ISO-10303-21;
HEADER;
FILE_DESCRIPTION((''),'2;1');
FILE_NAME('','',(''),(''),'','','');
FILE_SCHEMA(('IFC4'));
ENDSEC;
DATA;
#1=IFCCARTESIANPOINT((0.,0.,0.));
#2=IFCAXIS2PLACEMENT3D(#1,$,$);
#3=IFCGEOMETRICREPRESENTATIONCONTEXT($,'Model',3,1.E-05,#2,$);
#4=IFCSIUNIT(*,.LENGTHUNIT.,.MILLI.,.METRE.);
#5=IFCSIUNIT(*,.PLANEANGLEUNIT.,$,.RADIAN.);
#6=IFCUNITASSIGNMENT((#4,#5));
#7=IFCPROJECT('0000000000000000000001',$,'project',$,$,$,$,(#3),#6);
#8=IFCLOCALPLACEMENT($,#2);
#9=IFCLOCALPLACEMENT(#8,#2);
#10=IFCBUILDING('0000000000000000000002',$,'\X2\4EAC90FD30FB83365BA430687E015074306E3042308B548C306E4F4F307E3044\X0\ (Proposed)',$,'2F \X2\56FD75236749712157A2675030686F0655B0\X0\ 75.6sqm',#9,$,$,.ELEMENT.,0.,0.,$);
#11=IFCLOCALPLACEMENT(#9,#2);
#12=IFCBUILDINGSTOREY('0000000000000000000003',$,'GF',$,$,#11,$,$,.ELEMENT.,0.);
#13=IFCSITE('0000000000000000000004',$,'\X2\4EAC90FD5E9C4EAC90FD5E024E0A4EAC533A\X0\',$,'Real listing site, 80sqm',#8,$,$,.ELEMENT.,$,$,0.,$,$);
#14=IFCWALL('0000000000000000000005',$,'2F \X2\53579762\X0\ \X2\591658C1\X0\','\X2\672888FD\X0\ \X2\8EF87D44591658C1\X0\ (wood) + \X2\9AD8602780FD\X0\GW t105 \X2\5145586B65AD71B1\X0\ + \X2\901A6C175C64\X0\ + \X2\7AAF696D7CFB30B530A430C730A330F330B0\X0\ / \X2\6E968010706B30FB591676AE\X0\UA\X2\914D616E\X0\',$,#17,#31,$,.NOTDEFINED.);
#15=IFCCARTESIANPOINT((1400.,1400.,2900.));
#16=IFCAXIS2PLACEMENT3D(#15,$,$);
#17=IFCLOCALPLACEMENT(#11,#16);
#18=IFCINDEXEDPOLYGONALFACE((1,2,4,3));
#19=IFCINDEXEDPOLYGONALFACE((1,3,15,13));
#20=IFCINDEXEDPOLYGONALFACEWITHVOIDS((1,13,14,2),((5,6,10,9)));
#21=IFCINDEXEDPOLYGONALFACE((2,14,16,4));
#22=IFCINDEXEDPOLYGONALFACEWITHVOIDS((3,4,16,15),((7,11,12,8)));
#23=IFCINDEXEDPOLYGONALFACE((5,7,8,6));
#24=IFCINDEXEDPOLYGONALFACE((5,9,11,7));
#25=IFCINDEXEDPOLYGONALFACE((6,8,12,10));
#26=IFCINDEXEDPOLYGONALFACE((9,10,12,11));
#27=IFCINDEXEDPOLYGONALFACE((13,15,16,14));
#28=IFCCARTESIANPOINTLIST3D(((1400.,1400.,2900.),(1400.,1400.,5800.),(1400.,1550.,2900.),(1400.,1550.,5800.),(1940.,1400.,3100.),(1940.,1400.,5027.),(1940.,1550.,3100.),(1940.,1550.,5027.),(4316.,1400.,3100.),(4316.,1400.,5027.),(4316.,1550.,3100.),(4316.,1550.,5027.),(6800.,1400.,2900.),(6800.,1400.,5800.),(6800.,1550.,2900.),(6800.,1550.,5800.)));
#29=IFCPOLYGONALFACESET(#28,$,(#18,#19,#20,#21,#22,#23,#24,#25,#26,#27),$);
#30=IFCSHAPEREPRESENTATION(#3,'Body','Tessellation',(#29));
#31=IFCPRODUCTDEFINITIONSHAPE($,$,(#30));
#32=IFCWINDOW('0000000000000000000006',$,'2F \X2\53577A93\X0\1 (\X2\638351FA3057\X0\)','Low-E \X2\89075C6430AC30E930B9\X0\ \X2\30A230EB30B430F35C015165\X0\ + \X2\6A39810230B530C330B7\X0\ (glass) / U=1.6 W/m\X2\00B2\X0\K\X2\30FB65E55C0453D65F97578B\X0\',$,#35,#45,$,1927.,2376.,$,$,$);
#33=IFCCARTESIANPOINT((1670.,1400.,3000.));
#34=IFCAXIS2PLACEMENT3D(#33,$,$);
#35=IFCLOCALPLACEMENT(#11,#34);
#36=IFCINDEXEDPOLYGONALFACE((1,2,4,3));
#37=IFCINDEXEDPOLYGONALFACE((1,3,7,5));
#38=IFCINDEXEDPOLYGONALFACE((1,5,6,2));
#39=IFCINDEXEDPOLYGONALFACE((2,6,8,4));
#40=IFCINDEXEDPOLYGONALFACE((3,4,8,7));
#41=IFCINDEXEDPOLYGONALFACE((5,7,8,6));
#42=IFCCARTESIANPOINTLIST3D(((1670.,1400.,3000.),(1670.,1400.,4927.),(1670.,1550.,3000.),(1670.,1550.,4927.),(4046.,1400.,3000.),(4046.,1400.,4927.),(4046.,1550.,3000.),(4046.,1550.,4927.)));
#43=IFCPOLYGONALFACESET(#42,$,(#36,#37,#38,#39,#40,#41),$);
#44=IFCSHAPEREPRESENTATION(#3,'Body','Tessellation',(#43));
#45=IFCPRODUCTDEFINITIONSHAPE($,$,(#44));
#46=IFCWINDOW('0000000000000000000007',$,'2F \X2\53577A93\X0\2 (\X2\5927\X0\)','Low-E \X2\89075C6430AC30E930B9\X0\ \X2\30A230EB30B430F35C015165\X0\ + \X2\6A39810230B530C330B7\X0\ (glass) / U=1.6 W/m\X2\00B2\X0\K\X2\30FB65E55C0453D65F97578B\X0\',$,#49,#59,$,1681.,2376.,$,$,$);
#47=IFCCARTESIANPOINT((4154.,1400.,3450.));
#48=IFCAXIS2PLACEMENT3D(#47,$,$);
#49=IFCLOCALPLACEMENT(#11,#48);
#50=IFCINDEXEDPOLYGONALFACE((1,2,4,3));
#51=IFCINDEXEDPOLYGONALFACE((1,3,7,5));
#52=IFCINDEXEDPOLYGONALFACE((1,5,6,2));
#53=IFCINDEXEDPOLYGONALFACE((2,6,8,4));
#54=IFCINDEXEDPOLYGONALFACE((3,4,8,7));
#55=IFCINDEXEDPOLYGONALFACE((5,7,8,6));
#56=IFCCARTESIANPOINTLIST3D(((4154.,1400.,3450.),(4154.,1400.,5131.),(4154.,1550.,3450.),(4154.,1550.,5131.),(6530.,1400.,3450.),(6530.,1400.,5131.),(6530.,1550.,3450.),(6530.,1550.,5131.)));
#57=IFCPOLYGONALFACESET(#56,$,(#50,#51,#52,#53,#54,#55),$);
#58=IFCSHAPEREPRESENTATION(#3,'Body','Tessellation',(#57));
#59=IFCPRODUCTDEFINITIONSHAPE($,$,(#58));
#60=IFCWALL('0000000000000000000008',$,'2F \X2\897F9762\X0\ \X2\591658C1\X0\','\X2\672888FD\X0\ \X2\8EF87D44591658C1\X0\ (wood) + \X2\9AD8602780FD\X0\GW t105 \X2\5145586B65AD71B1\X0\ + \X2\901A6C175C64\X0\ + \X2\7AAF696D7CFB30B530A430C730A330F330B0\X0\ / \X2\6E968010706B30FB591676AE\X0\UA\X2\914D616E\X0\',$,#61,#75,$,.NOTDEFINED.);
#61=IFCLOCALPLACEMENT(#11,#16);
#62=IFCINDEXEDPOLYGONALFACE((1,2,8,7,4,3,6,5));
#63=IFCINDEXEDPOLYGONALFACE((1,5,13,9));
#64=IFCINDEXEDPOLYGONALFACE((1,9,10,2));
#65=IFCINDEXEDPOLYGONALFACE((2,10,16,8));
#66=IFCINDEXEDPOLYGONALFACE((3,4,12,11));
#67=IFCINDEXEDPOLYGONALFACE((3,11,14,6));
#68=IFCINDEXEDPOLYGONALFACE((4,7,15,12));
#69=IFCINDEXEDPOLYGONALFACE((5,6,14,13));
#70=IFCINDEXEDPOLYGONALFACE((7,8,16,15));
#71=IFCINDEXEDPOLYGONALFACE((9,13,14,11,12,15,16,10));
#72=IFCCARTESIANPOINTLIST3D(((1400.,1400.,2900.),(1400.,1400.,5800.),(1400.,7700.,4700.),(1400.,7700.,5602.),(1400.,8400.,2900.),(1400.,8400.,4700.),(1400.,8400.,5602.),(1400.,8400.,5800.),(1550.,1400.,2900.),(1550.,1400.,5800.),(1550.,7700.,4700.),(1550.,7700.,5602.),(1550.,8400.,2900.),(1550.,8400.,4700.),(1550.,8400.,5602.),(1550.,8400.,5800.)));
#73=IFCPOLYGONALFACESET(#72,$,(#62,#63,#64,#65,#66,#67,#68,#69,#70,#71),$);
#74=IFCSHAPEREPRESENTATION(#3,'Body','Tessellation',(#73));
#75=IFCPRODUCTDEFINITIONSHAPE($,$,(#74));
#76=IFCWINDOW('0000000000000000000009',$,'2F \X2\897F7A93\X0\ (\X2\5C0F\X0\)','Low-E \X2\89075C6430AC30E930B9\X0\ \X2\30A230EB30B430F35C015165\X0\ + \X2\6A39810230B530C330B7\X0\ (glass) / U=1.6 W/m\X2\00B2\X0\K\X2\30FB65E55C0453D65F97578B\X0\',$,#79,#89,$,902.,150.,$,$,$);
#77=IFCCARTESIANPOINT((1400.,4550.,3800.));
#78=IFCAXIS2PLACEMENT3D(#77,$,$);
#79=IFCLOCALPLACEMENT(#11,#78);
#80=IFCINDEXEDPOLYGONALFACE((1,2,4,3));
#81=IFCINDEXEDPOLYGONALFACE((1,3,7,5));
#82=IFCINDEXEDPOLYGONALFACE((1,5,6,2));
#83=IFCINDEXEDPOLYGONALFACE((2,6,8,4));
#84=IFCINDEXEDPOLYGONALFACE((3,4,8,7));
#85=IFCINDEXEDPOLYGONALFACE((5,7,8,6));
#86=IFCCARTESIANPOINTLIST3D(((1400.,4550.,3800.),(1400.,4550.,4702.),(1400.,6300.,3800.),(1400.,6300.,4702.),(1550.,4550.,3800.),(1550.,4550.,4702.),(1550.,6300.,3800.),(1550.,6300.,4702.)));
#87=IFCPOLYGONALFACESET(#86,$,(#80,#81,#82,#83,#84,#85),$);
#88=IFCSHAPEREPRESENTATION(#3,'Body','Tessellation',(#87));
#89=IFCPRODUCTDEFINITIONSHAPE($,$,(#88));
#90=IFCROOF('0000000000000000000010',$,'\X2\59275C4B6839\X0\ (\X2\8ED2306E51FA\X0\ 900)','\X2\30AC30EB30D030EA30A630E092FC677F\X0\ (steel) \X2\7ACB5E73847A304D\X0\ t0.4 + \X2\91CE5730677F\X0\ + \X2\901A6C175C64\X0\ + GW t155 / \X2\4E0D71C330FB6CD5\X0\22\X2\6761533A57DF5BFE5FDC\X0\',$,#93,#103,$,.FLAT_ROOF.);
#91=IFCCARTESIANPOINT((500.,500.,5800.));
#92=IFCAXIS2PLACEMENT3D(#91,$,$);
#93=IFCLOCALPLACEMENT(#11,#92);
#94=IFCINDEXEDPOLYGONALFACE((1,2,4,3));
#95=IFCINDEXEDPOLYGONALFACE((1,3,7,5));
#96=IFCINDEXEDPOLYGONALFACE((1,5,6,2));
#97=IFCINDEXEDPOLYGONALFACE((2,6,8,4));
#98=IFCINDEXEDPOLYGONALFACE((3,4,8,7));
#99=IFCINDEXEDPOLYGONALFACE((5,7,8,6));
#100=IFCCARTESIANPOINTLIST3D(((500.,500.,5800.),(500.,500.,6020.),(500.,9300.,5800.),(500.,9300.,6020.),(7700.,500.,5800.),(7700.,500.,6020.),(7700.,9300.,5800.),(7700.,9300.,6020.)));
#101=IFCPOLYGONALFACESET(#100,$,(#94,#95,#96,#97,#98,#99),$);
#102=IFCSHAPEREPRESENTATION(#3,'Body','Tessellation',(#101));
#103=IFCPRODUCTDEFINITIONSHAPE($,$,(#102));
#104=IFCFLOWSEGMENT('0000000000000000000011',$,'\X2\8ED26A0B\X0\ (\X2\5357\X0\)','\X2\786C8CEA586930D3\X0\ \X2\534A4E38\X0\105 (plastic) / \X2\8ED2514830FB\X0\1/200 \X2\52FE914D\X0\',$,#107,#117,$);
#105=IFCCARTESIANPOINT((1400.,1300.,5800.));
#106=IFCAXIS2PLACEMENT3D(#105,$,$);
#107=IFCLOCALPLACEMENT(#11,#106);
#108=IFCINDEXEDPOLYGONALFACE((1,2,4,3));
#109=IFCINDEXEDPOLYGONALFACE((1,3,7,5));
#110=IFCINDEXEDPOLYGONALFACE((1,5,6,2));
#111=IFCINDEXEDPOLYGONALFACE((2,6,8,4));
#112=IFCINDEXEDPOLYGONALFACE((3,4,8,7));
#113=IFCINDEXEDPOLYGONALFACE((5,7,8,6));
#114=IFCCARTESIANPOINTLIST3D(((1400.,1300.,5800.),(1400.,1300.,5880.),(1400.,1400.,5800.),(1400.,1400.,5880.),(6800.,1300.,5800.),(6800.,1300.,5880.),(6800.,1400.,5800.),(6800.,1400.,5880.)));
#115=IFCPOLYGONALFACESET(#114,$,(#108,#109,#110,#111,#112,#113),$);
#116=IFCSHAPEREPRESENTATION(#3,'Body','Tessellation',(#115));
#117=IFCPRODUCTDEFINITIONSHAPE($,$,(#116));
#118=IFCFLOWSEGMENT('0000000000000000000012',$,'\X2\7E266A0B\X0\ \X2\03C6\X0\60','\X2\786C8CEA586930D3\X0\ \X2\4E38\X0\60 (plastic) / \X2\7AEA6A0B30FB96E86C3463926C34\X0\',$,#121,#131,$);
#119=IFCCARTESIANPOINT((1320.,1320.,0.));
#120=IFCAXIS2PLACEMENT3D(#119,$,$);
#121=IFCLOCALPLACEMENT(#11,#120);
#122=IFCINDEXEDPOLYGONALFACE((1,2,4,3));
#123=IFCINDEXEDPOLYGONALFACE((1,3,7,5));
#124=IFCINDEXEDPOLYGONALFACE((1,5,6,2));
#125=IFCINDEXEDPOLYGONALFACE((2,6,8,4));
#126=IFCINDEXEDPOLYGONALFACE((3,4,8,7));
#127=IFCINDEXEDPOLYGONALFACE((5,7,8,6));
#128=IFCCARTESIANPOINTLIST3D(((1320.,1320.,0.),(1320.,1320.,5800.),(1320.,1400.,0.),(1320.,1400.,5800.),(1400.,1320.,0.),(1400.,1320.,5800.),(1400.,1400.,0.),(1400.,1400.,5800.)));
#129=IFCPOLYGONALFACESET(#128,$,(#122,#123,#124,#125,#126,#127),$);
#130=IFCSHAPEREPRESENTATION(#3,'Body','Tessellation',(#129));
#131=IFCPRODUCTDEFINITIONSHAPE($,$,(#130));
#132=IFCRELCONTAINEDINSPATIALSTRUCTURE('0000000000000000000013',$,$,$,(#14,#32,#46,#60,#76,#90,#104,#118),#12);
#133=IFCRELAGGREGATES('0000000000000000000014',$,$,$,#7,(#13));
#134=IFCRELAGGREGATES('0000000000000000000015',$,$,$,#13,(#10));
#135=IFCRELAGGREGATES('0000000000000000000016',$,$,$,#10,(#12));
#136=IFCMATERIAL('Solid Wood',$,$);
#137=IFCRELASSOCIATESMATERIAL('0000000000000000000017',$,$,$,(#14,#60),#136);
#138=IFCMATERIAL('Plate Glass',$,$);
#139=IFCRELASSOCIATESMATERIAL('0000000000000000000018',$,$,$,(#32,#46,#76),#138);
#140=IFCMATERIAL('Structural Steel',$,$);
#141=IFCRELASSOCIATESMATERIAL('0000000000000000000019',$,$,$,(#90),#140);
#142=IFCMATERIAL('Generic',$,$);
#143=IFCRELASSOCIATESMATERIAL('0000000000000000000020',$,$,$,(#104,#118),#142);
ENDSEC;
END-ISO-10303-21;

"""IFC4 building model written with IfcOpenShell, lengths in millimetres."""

from ifc_helpers import new_model, si_unit, frame, frame_2d, origin, place, context, project, spatial, rectangle, extrude, material, element, fill, save


model = new_model("IFC4")

# Units and contexts
model_context = context("Model", 3, precision=1e-05, world=origin())
ifc_project = project(units=[si_unit("LENGTHUNIT", "METRE", prefix="MILLI"), si_unit("PLANEANGLEUNIT", "RADIAN")], contexts=[model_context])

# Site, building, storey
site_placement = place(None, origin())
site = spatial("IfcSite", under=ifc_project, at=site_placement, Name="京都府京都市上京区", ObjectType="Real listing site, 80sqm", CompositionType="ELEMENT", RefElevation=0.0)
building_placement = place(site_placement, origin())
building = spatial("IfcBuilding", under=site, at=building_placement, Name="京都・茶室と縁側のある和の住まい (Proposed)", ObjectType="2F 国産杉無垢材と漆喰 75.6sqm", CompositionType="ELEMENT", ElevationOfRefHeight=0.0, ElevationOfTerrain=0.0)
storey_placement = place(building_placement, origin())
storey = spatial("IfcBuildingStorey", under=building, at=storey_placement, Name="GF", CompositionType="ELEMENT", Elevation=0.0)

# Shared definitions
ifc_material_1 = material(Name="Solid Wood")

# Shared definitions
ifc_material_2 = material(Name="Plate Glass")

# Wall, openings, windows
wall_1_placement = place(storey_placement, frame((1400.0, 1400.0, 2900.0)))
wall_1 = element("IfcWall", 1, at=wall_1_placement, inside=storey, material=ifc_material_1, Name="2F 南面 外壁", Description="木製 軸組外壁 (wood) + 高性能GW t105 充填断熱 + 通気層 + 窯業系サイディング / 準耐火・外皮UA配慮", PredefinedType="NOTDEFINED", context=model_context, shape_type="SweptSolid", body=[
    extrude(rectangle(XDim=5400.0, YDim=150.0, at=frame_2d((2700.0, 75.0))), frame((1400.0, 1400.0, 2900.0)), (0.0, 0.0, 1.0), 2900.0),
])
opening_1_placement = place(storey_placement, frame((1670.0, 1400.0, 3000.0)))
opening_1 = element("IfcOpeningElement", 2, at=opening_1_placement, cuts=wall_1, PredefinedType="NOTDEFINED", context=model_context, shape_type="SweptSolid", body=[
    extrude(rectangle(XDim=2376.0, YDim=150.0, at=frame_2d((1188.0, 75.0))), frame((1670.0, 1400.0, 3000.0)), (0.0, 0.0, 1.0), 1927.0),
])
opening_2_placement = place(storey_placement, frame((4154.0, 1400.0, 3450.0)))
opening_2 = element("IfcOpeningElement", 3, at=opening_2_placement, cuts=wall_1, PredefinedType="NOTDEFINED", context=model_context, shape_type="SweptSolid", body=[
    extrude(rectangle(XDim=2376.0, YDim=150.0, at=frame_2d((1188.0, 75.0))), frame((4154.0, 1400.0, 3450.0)), (0.0, 0.0, 1.0), 1681.0),
])
window_1_placement = place(storey_placement, frame((1670.0, 1400.0, 3000.0)))
window_1 = element("IfcWindow", 4, at=window_1_placement, inside=storey, material=ifc_material_2, Name="2F 南窓1 (掃出し)", Description="Low-E 複層ガラス アルゴン封入 + 樹脂サッシ (glass) / U=1.6 W/m²K・日射取得型", OverallHeight=1927.0, OverallWidth=2376.0, context=model_context, shape_type="SweptSolid", body=[
    extrude(rectangle(XDim=2376.0, YDim=150.0, at=frame_2d((1188.0, 75.0))), frame((1670.0, 1400.0, 3000.0)), (0.0, 0.0, 1.0), 1927.0),
])
fill(opening_1, window_1)
window_2_placement = place(storey_placement, frame((4154.0, 1400.0, 3450.0)))
window_2 = element("IfcWindow", 5, at=window_2_placement, inside=storey, material=ifc_material_2, Name="2F 南窓2 (大)", Description="Low-E 複層ガラス アルゴン封入 + 樹脂サッシ (glass) / U=1.6 W/m²K・日射取得型", OverallHeight=1681.0, OverallWidth=2376.0, context=model_context, shape_type="SweptSolid", body=[
    extrude(rectangle(XDim=2376.0, YDim=150.0, at=frame_2d((1188.0, 75.0))), frame((4154.0, 1400.0, 3450.0)), (0.0, 0.0, 1.0), 1681.0),
])
fill(opening_2, window_2)

# Wall, opening, window
wall_2_placement = place(storey_placement, frame((1400.0, 1400.0, 2900.0)))
wall_2 = element("IfcWall", 6, at=wall_2_placement, inside=storey, material=ifc_material_1, Name="2F 西面 外壁", Description="木製 軸組外壁 (wood) + 高性能GW t105 充填断熱 + 通気層 + 窯業系サイディング / 準耐火・外皮UA配慮", PredefinedType="NOTDEFINED", context=model_context, shape_type="SweptSolid", body=[
    extrude(rectangle(XDim=150.0, YDim=7000.0, at=frame_2d((75.0, 3500.0))), frame((1400.0, 1400.0, 2900.0)), (0.0, 0.0, 1.0), 2900.0),
])
opening_3_placement = place(storey_placement, frame((1400.0, 4550.0, 3800.0)))
opening_3 = element("IfcOpeningElement", 7, at=opening_3_placement, cuts=wall_2, PredefinedType="NOTDEFINED", context=model_context, shape_type="SweptSolid", body=[
    extrude(rectangle(XDim=150.0, YDim=1750.0, at=frame_2d((75.0, 875.0))), frame((1400.0, 4550.0, 3800.0)), (0.0, 0.0, 1.0), 902.0),
])
window_3_placement = place(storey_placement, frame((1400.0, 4550.0, 3800.0)))
window_3 = element("IfcWindow", 8, at=window_3_placement, inside=storey, material=ifc_material_2, Name="2F 西窓 (小)", Description="Low-E 複層ガラス アルゴン封入 + 樹脂サッシ (glass) / U=1.6 W/m²K・日射取得型", OverallHeight=902.0, OverallWidth=150.0, context=model_context, shape_type="SweptSolid", body=[
    extrude(rectangle(XDim=150.0, YDim=1750.0, at=frame_2d((75.0, 875.0))), frame((1400.0, 4550.0, 3800.0)), (0.0, 0.0, 1.0), 902.0),
])
fill(opening_3, window_3)

# Roof
ifc_material_3 = material(Name="Structural Steel")
roof_placement = place(storey_placement, frame((500.0, 500.0, 5800.0)))
element("IfcRoof", 9, at=roof_placement, inside=storey, material=ifc_material_3, Name="大屋根 (軒の出 900)", Description="ガルバリウム鋼板 (steel) 立平葺き t0.4 + 野地板 + 通気層 + GW t155 / 不燃・法22条区域対応", PredefinedType="FLAT_ROOF", context=model_context, shape_type="SweptSolid", body=[
    extrude(rectangle(XDim=7200.0, YDim=8800.0, at=frame_2d((3600.0, 4400.0))), frame((500.0, 500.0, 5800.0)), (0.0, 0.0, 1.0), 220.0),
])

# Flow segments
ifc_material_4 = material(Name="Generic")
flow_segment_1_placement = place(storey_placement, frame((1400.0, 1300.0, 5800.0)))
element("IfcFlowSegment", 10, at=flow_segment_1_placement, inside=storey, material=ifc_material_4, Name="軒樋 (南)", Description="硬質塩ビ 半丸105 (plastic) / 軒先・1/200 勾配", context=model_context, shape_type="SweptSolid", body=[
    extrude(rectangle(XDim=5400.0, YDim=100.0, at=frame_2d((2700.0, 50.0))), frame((1400.0, 1300.0, 5800.0)), (0.0, 0.0, 1.0), 80.0),
])
flow_segment_2_placement = place(storey_placement, frame((1320.0, 1320.0, 0.0)))
element("IfcFlowSegment", 11, at=flow_segment_2_placement, inside=storey, material=ifc_material_4, Name="縦樋 φ60", Description="硬質塩ビ 丸60 (plastic) / 竪樋・雨水排水", context=model_context, shape_type="SweptSolid", body=[
    extrude(rectangle(XDim=80.0, YDim=80.0, at=frame_2d((40.0, 40.0))), frame((1320.0, 1320.0, 0.0)), (0.0, 0.0, 1.0), 5800.0),
])

save(model, "model.ifc")
